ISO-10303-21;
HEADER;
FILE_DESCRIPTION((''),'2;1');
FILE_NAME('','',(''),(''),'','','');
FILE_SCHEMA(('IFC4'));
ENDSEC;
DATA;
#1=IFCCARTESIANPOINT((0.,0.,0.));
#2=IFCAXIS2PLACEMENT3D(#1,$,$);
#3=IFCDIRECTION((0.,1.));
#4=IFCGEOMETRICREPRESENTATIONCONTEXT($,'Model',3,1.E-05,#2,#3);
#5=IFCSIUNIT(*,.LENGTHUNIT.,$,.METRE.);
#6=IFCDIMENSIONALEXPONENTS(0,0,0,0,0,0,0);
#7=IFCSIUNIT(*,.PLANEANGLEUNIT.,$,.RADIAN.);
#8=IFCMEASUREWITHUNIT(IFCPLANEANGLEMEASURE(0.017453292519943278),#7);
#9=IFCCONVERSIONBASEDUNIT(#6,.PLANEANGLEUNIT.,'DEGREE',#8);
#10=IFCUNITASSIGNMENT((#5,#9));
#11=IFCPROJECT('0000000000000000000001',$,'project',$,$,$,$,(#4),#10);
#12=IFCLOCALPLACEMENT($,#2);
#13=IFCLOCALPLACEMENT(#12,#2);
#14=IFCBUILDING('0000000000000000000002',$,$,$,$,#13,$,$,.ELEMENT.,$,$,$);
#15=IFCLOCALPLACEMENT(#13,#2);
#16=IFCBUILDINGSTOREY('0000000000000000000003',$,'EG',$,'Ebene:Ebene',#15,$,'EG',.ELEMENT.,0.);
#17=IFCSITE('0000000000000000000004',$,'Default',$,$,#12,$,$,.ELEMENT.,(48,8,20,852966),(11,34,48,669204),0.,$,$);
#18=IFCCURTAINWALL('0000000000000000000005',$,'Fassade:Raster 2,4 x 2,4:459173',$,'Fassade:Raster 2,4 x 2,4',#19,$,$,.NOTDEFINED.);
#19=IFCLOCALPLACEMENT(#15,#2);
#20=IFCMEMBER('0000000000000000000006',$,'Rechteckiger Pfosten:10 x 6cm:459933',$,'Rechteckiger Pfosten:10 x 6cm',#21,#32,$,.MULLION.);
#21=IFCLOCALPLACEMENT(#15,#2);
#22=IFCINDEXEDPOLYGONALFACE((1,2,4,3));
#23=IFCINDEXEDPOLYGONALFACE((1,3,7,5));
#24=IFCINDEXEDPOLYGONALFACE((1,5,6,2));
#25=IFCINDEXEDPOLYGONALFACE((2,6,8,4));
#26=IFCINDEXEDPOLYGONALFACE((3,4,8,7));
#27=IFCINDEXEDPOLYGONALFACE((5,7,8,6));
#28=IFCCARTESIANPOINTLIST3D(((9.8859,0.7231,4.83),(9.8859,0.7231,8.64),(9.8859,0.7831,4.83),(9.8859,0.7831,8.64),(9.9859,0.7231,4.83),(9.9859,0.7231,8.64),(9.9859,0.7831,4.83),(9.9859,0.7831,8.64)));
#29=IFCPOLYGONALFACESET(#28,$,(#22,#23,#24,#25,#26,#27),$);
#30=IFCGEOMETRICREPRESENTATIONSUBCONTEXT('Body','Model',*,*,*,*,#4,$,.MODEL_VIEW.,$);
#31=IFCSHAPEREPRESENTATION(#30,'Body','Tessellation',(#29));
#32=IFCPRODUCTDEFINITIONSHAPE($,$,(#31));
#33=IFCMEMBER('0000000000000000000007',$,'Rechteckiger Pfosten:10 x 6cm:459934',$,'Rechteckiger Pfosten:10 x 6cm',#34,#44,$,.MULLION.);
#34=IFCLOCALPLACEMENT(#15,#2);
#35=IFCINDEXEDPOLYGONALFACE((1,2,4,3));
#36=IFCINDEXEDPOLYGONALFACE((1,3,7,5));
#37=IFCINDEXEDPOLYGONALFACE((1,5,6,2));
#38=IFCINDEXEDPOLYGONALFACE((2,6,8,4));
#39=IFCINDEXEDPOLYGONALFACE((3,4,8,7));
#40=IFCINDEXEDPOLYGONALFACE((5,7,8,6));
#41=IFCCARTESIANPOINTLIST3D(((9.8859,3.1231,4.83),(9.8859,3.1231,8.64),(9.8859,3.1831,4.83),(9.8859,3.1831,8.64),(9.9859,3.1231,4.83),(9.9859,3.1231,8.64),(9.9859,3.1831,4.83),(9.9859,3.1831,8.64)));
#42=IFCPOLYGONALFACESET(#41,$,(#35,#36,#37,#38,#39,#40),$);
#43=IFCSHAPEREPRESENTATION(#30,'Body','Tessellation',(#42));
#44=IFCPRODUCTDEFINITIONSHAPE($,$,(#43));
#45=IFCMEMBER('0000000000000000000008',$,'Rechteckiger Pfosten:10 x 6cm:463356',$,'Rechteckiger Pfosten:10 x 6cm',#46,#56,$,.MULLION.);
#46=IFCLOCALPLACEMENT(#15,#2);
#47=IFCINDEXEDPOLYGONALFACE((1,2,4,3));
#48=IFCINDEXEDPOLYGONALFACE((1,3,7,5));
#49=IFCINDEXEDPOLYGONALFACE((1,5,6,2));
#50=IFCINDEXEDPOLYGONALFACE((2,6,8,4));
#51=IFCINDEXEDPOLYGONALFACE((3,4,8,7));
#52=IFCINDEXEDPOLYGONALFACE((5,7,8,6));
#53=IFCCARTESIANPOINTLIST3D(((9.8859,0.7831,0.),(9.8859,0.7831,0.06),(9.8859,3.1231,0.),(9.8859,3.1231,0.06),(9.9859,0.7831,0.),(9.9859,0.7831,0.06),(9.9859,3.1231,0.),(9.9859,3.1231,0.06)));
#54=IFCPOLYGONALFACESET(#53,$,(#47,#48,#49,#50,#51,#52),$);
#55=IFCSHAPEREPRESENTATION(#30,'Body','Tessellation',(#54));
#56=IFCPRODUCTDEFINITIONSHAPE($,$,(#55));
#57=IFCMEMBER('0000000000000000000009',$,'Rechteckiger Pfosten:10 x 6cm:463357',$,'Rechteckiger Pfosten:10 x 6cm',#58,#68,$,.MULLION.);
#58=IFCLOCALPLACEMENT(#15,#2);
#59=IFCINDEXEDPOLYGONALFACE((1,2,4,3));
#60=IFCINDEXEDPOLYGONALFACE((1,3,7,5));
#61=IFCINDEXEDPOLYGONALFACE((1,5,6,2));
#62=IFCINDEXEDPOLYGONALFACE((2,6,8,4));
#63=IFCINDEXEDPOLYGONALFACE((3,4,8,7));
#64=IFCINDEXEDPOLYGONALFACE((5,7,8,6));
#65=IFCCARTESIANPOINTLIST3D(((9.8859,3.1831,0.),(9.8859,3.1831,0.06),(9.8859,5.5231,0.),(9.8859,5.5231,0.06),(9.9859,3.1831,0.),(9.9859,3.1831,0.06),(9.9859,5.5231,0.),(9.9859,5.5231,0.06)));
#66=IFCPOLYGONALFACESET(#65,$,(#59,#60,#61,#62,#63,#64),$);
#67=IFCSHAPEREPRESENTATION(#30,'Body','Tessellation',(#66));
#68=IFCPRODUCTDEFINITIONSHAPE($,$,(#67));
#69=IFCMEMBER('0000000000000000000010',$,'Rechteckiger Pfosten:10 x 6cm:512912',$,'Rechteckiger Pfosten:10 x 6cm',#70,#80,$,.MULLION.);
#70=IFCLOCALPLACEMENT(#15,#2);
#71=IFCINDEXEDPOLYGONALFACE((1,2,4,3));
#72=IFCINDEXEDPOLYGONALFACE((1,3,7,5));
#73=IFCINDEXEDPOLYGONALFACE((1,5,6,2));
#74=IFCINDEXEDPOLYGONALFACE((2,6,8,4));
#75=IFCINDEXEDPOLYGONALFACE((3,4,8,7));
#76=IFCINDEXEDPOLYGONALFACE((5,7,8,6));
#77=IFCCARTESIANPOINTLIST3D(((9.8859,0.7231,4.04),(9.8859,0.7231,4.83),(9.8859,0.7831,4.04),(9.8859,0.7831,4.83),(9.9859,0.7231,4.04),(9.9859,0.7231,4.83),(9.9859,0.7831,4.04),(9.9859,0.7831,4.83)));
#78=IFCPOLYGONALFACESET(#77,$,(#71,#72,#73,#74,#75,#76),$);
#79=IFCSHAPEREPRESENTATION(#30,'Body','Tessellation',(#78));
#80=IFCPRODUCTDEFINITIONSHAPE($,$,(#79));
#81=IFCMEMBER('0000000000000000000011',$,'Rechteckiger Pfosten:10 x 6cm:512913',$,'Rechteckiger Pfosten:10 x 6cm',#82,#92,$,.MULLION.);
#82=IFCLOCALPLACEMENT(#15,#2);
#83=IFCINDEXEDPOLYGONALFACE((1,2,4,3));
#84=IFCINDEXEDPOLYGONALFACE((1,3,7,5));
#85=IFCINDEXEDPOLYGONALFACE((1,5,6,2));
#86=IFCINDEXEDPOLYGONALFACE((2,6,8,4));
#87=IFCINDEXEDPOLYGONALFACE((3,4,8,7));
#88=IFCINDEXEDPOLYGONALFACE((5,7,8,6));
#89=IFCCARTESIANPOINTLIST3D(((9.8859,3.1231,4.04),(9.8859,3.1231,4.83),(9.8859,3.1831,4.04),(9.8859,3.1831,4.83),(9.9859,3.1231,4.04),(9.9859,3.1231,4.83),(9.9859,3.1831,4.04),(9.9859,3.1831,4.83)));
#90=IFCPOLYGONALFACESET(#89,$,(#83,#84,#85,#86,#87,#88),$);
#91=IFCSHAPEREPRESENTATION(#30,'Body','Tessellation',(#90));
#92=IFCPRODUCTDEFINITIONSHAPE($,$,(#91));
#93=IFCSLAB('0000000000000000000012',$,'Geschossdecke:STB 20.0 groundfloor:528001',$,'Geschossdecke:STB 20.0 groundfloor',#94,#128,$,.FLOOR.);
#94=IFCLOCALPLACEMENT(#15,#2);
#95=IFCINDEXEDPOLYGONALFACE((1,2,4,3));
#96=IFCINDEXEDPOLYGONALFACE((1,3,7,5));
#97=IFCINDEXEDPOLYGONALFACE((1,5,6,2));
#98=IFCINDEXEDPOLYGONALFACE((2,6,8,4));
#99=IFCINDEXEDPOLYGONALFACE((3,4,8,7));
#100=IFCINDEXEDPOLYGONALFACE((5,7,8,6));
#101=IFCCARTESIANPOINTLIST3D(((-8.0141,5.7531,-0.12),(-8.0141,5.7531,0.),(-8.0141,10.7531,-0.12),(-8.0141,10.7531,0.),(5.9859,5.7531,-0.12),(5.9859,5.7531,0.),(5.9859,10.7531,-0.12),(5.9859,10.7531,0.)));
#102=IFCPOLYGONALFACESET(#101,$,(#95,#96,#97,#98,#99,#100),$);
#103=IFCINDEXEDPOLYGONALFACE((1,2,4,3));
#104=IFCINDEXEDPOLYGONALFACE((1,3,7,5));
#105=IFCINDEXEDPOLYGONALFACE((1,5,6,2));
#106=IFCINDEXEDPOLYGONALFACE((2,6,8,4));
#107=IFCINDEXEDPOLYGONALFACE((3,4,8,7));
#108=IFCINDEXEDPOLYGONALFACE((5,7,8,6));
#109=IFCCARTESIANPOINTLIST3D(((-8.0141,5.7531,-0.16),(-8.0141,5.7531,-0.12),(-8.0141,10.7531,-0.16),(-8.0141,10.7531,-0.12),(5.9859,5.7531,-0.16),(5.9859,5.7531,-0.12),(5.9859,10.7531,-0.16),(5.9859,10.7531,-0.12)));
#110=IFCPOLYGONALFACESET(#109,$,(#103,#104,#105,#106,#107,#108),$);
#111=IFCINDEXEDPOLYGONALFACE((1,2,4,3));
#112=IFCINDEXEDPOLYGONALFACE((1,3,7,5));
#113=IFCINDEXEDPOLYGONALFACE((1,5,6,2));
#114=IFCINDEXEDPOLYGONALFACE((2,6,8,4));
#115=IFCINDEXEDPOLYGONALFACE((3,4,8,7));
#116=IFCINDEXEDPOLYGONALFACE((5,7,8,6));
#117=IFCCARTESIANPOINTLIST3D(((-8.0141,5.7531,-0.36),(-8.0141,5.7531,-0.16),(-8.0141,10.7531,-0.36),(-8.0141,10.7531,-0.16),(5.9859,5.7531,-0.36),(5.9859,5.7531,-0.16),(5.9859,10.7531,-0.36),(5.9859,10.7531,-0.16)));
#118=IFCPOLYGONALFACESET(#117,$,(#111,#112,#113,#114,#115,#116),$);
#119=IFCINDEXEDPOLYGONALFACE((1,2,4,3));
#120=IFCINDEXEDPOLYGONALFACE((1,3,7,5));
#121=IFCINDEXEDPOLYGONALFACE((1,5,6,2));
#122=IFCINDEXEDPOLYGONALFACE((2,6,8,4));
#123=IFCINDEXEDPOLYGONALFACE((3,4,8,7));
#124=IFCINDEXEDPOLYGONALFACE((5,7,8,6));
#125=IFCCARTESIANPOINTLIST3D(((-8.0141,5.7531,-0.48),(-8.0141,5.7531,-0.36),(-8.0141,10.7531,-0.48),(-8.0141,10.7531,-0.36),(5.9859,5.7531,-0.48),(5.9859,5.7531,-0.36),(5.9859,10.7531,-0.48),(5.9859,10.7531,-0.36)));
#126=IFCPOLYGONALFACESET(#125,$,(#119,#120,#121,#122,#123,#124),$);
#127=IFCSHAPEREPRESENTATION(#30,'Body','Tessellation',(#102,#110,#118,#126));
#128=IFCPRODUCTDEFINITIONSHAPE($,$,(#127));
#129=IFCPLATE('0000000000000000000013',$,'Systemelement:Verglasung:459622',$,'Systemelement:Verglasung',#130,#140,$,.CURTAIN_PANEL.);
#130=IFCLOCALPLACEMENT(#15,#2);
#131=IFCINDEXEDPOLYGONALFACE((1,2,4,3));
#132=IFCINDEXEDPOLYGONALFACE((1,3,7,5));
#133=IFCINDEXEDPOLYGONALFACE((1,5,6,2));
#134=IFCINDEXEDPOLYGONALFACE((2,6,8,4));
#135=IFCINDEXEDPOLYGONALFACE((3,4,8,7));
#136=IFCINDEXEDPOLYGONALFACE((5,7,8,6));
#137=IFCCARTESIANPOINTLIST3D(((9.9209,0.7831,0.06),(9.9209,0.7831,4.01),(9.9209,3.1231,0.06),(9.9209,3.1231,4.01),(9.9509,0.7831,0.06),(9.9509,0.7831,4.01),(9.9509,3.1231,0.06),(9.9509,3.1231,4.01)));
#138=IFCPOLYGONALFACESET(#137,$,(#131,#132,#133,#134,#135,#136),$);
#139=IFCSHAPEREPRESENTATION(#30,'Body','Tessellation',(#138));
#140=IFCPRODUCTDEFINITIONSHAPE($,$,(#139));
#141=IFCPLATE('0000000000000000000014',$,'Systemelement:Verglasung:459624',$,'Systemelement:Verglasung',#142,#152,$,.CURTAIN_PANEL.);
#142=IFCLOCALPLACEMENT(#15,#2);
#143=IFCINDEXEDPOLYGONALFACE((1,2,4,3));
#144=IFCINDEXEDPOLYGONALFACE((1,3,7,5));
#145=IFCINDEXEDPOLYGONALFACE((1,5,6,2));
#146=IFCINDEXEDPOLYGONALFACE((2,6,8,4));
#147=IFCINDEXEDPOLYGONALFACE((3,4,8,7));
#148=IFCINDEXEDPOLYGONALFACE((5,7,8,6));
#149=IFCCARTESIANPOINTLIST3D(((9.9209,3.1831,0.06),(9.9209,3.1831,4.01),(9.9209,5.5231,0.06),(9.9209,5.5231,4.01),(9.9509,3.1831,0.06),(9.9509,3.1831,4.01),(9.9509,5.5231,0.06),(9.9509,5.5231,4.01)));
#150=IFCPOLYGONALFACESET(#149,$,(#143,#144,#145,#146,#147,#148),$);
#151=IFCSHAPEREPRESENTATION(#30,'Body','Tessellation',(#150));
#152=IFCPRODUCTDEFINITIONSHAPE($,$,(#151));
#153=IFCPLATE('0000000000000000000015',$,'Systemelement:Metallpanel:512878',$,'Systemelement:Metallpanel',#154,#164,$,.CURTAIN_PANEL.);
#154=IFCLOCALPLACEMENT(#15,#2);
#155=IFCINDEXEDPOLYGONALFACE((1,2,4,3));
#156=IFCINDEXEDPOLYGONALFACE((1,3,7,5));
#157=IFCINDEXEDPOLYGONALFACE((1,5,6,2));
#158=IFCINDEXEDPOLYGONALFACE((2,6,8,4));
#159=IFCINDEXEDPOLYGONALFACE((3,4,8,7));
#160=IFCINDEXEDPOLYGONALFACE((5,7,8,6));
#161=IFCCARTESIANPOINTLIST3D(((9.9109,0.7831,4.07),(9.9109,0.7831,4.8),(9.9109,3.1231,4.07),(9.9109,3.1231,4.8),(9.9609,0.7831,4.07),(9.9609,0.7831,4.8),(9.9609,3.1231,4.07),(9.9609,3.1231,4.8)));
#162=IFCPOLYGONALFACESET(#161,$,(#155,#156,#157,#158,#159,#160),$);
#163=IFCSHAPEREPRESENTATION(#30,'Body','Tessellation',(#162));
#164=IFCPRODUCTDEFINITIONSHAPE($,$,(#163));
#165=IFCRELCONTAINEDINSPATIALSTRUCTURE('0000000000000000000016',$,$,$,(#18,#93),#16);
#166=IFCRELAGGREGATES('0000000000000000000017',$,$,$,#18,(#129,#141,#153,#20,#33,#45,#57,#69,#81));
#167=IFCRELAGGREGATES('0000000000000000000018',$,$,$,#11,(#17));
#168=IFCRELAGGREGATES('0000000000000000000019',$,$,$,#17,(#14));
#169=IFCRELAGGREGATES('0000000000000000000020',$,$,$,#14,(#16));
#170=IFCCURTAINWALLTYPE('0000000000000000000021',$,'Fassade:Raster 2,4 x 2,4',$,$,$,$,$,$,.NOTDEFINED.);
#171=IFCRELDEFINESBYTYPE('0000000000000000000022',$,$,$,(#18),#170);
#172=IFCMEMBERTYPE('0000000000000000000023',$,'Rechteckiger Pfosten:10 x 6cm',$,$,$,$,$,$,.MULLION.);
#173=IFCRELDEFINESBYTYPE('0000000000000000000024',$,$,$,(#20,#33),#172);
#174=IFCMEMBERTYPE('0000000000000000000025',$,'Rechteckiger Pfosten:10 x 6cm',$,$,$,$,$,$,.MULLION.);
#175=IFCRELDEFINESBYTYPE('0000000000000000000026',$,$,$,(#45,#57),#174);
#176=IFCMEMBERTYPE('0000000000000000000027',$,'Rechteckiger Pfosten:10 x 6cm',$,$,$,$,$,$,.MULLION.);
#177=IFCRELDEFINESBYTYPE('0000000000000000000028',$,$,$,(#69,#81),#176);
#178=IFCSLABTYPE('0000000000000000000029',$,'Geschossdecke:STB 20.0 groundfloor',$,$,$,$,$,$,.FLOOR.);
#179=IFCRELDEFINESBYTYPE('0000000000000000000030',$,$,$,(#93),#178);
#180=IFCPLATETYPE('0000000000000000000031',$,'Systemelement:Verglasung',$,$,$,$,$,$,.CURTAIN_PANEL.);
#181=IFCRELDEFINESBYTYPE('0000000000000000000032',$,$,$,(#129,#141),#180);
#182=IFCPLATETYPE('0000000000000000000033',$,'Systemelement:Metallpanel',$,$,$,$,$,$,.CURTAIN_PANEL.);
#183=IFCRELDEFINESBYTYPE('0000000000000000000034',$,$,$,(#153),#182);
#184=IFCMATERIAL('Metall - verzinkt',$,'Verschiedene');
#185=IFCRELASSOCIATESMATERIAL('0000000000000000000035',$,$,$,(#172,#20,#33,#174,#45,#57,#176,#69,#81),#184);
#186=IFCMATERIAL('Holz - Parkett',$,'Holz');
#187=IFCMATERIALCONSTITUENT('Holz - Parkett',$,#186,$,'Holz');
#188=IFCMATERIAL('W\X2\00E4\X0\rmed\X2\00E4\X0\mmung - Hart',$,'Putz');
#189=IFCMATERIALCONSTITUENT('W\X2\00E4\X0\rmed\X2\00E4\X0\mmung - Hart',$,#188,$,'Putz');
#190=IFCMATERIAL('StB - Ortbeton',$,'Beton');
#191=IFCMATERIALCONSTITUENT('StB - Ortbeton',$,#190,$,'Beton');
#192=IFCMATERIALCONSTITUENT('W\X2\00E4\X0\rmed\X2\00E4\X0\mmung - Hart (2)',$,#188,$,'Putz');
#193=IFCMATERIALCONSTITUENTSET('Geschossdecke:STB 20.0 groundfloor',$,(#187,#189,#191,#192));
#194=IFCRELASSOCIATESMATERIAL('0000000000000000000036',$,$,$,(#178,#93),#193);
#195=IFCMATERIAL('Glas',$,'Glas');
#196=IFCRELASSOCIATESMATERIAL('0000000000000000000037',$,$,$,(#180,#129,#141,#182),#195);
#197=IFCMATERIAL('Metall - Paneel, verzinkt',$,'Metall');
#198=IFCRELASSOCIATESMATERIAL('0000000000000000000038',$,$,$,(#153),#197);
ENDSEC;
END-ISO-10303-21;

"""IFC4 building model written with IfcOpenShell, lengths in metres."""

from ifc_helpers import new_model, entity, si_unit, converted_unit, direction, frame, origin, place, context, subcontext, project, spatial, indexed_curve, outline, extrude, source, transform, mapped, material, constituent, constituent_set, type_object, type_shapes, element, aggregate, save


model = new_model("IFC4")

# Units and contexts
model_context = context("Model", 3, precision=1e-05, world=origin(), true_north=direction((0.0, 1.0)))
body_context = subcontext(model_context, "Body", "Model", "MODEL_VIEW")
ifc_project = project(units=[si_unit("LENGTHUNIT", "METRE"), converted_unit("PLANEANGLEUNIT", "DEGREE", entity("IfcPlaneAngleMeasure", 0.017453292519943278), si_unit("PLANEANGLEUNIT", "RADIAN"), dimensions=[0, 0, 0, 0, 0, 0, 0])], contexts=[model_context])

# Site, building, storey
site_placement = place(None, origin())
site = spatial("IfcSite", under=ifc_project, at=site_placement, Name="Default", CompositionType="ELEMENT", RefLatitude=(48, 8, 20, 852966), RefLongitude=(11, 34, 48, 669204), RefElevation=0.0)
building_placement = place(site_placement, origin())
building = spatial("IfcBuilding", under=site, at=building_placement, CompositionType="ELEMENT")
storey_placement = place(building_placement, origin())
storey = spatial("IfcBuildingStorey", under=building, at=storey_placement, Name="EG", ObjectType="Ebene:Ebene", LongName="EG", CompositionType="ELEMENT", Elevation=0.0)

# Curtain wall, members
curtain_wall_type = type_object("IfcCurtainWallType", Name="Fassade:Raster 2,4 x 2,4", PredefinedType="NOTDEFINED")
curtain_wall_placement = place(storey_placement, origin())
curtain_wall = element("IfcCurtainWall", 1, at=curtain_wall_placement, inside=storey, type_object=curtain_wall_type, Name="Fassade:Raster 2,4 x 2,4:459173", ObjectType="Fassade:Raster 2,4 x 2,4", PredefinedType="NOTDEFINED")
ifc_material_1 = material(Name="Metall - verzinkt", Category="Verschiedene")
member_type_1 = type_object("IfcMemberType", Name="Rechteckiger Pfosten:10 x 6cm", PredefinedType="MULLION", material=ifc_material_1)
shared_shape_1 = source(origin(), body_context, "Body", "SweptSolid", [
    extrude(outline(indexed_curve([(-0.03, -0.05), (0.03, -0.05), (0.03, 0.05), (-0.03, 0.05), (-0.03, -0.05)], self_intersect=False)), frame((0.0, 0.0, -3.81), z_axis=(0.0, 0.0, 1.0), x_axis=(-1.0, 0.0, 0.0)), (0.0, 0.0, 1.0), 3.81),
])
type_shapes(member_type_1, [shared_shape_1])
member_1_placement = place(curtain_wall_placement, frame((9.9359, 0.7531, 4.83), z_axis=(0.0, 0.0, -1.0), x_axis=(0.0, 1.0, 0.0)))
member_1 = element("IfcMember", 2, at=member_1_placement, type_object=member_type_1, material=ifc_material_1, Name="Rechteckiger Pfosten:10 x 6cm:459933", ObjectType="Rechteckiger Pfosten:10 x 6cm", PredefinedType="MULLION", context=body_context, shape_type="MappedRepresentation", body=[
    mapped(shared_shape_1, transform((0.0, 0.0, 0.0), scale=1.0)),
])
member_2_placement = place(curtain_wall_placement, frame((9.9359, 3.1531, 4.83), z_axis=(0.0, 0.0, -1.0), x_axis=(0.0, 1.0, 0.0)))
member_2 = element("IfcMember", 3, at=member_2_placement, type_object=member_type_1, material=ifc_material_1, Name="Rechteckiger Pfosten:10 x 6cm:459934", ObjectType="Rechteckiger Pfosten:10 x 6cm", PredefinedType="MULLION", context=body_context, shape_type="MappedRepresentation", body=[
    mapped(shared_shape_1, transform((0.0, 0.0, 0.0), scale=1.0)),
])
member_type_2 = type_object("IfcMemberType", Name="Rechteckiger Pfosten:10 x 6cm", PredefinedType="MULLION", material=ifc_material_1)
shared_shape_2 = source(origin(), body_context, "Body", "SweptSolid", [
    extrude(outline(indexed_curve([(-0.03, -0.05), (0.03, -0.05), (0.03, 0.05), (-0.03, 0.05), (-0.03, -0.05)], self_intersect=False)), frame((-0.03, 0.0, -2.34), z_axis=(0.0, 0.0, 1.0), x_axis=(-1.0, 0.0, 0.0)), (0.0, 0.0, 1.0), 2.34),
])
type_shapes(member_type_2, [shared_shape_2])
member_3_placement = place(curtain_wall_placement, frame((9.9359, 0.7831, 0.0), z_axis=(0.0, -1.0, 0.0), x_axis=(0.0, 0.0, -1.0)))
member_3 = element("IfcMember", 4, at=member_3_placement, type_object=member_type_2, material=ifc_material_1, Name="Rechteckiger Pfosten:10 x 6cm:463356", ObjectType="Rechteckiger Pfosten:10 x 6cm", PredefinedType="MULLION", context=body_context, shape_type="MappedRepresentation", body=[
    mapped(shared_shape_2, transform((0.0, 0.0, 0.0), scale=1.0)),
])
member_4_placement = place(curtain_wall_placement, frame((9.9359, 3.1831, 0.0), z_axis=(0.0, -1.0, 0.0), x_axis=(0.0, 0.0, -1.0)))
member_4 = element("IfcMember", 5, at=member_4_placement, type_object=member_type_2, material=ifc_material_1, Name="Rechteckiger Pfosten:10 x 6cm:463357", ObjectType="Rechteckiger Pfosten:10 x 6cm", PredefinedType="MULLION", context=body_context, shape_type="MappedRepresentation", body=[
    mapped(shared_shape_2, transform((0.0, 0.0, 0.0), scale=1.0)),
])
member_type_3 = type_object("IfcMemberType", Name="Rechteckiger Pfosten:10 x 6cm", PredefinedType="MULLION", material=ifc_material_1)
shared_shape_3 = source(origin(), body_context, "Body", "SweptSolid", [
    extrude(outline(indexed_curve([(-0.03, -0.05), (0.03, -0.05), (0.03, 0.05), (-0.03, 0.05), (-0.03, -0.05)], self_intersect=False)), frame((0.0, 0.0, -0.79), z_axis=(0.0, 0.0, 1.0), x_axis=(-1.0, 0.0, 0.0)), (0.0, 0.0, 1.0), 0.79),
])
type_shapes(member_type_3, [shared_shape_3])
member_5_placement = place(curtain_wall_placement, frame((9.9359, 0.7531, 4.04), z_axis=(0.0, 0.0, -1.0), x_axis=(0.0, 1.0, 0.0)))
member_5 = element("IfcMember", 6, at=member_5_placement, type_object=member_type_3, material=ifc_material_1, Name="Rechteckiger Pfosten:10 x 6cm:512912", ObjectType="Rechteckiger Pfosten:10 x 6cm", PredefinedType="MULLION", context=body_context, shape_type="MappedRepresentation", body=[
    mapped(shared_shape_3, transform((0.0, 0.0, 0.0), scale=1.0)),
])
member_6_placement = place(curtain_wall_placement, frame((9.9359, 3.1531, 4.04), z_axis=(0.0, 0.0, -1.0), x_axis=(0.0, 1.0, 0.0)))
member_6 = element("IfcMember", 7, at=member_6_placement, type_object=member_type_3, material=ifc_material_1, Name="Rechteckiger Pfosten:10 x 6cm:512913", ObjectType="Rechteckiger Pfosten:10 x 6cm", PredefinedType="MULLION", context=body_context, shape_type="MappedRepresentation", body=[
    mapped(shared_shape_3, transform((0.0, 0.0, 0.0), scale=1.0)),
])

# Slab
ifc_material_2 = material(Name="Holz - Parkett", Category="Holz")
ifc_constituent_1 = constituent(ifc_material_2, Name="Holz - Parkett", Category="Holz")
ifc_material_3 = material(Name="Wärmedämmung - Hart", Category="Putz")
ifc_constituent_2 = constituent(ifc_material_3, Name="Wärmedämmung - Hart", Category="Putz")
ifc_material_4 = material(Name="StB - Ortbeton", Category="Beton")
ifc_constituent_3 = constituent(ifc_material_4, Name="StB - Ortbeton", Category="Beton")
ifc_constituent_4 = constituent(ifc_material_3, Name="Wärmedämmung - Hart (2)", Category="Putz")
ifc_constituent_set_1 = constituent_set(constituents=[ifc_constituent_1, ifc_constituent_2, ifc_constituent_3, ifc_constituent_4], Name="Geschossdecke:STB 20.0 groundfloor")
slab_type = type_object("IfcSlabType", Name="Geschossdecke:STB 20.0 groundfloor", PredefinedType="FLOOR", material=ifc_constituent_set_1)
slab_placement = place(storey_placement, origin())
element("IfcSlab", 8, at=slab_placement, inside=storey, type_object=slab_type, material=ifc_constituent_set_1, Name="Geschossdecke:STB 20.0 groundfloor:528001", ObjectType="Geschossdecke:STB 20.0 groundfloor", PredefinedType="FLOOR", context=body_context, shape_type="SweptSolid", body=[
    extrude(outline(indexed_curve([(-7.0, -2.5), (7.0, -2.5), (7.0, 2.5), (-7.0, 2.5), (-7.0, -2.5)], self_intersect=False)), frame((-1.0141, 8.2531, -0.12), z_axis=(0.0, 0.0, 1.0), x_axis=(-1.0, 0.0, 0.0)), (0.0, 0.0, 1.0), 0.12),
    extrude(outline(indexed_curve([(-7.0, -2.5), (7.0, -2.5), (7.0, 2.5), (-7.0, 2.5), (-7.0, -2.5)], self_intersect=False)), frame((-1.0141, 8.2531, -0.16), z_axis=(0.0, 0.0, 1.0), x_axis=(-1.0, 0.0, 0.0)), (0.0, 0.0, 1.0), 0.04),
    extrude(outline(indexed_curve([(-7.0, -2.5), (7.0, -2.5), (7.0, 2.5), (-7.0, 2.5), (-7.0, -2.5)], self_intersect=False)), frame((-1.0141, 8.2531, -0.36), z_axis=(0.0, 0.0, 1.0), x_axis=(-1.0, 0.0, 0.0)), (0.0, 0.0, 1.0), 0.2),
    extrude(outline(indexed_curve([(-2.5, -7.0), (2.5, -7.0), (2.5, 7.0), (-2.5, 7.0), (-2.5, -7.0)], self_intersect=False)), frame((-1.0141, 8.2531, -0.48), z_axis=(0.0, 0.0, 1.0), x_axis=(0.0, 1.0, 0.0)), (0.0, 0.0, 1.0), 0.12),
])

# Plates
ifc_material_5 = material(Name="Glas", Category="Glas")
plate_type_1 = type_object("IfcPlateType", Name="Systemelement:Verglasung", PredefinedType="CURTAIN_PANEL", material=ifc_material_5)
shared_shape_4 = source(origin(), body_context, "Body", "SweptSolid", [
    extrude(outline(indexed_curve([(-0.015, -1.17), (0.015, -1.17), (0.015, 1.17), (-0.015, 1.17), (-0.015, -1.17)], self_intersect=False)), frame((0.0, 0.0, 0.0), z_axis=(0.0, 0.0, 1.0), x_axis=(0.0, 1.0, 0.0)), (0.0, 0.0, 1.0), 3.95),
])
type_shapes(plate_type_1, [shared_shape_4])
plate_1_placement = place(curtain_wall_placement, frame((9.9359, 1.9531, 0.06), z_axis=(0.0, 0.0, 1.0), x_axis=(0.0, 1.0, 0.0)))
plate_1 = element("IfcPlate", 9, at=plate_1_placement, type_object=plate_type_1, material=ifc_material_5, Name="Systemelement:Verglasung:459622", ObjectType="Systemelement:Verglasung", PredefinedType="CURTAIN_PANEL", context=body_context, shape_type="MappedRepresentation", body=[
    mapped(shared_shape_4, transform((0.0, 0.0, 0.0), scale=1.0)),
])
plate_2_placement = place(curtain_wall_placement, frame((9.9359, 4.3531, 0.06), z_axis=(0.0, 0.0, 1.0), x_axis=(0.0, 1.0, 0.0)))
plate_2 = element("IfcPlate", 10, at=plate_2_placement, type_object=plate_type_1, material=ifc_material_5, Name="Systemelement:Verglasung:459624", ObjectType="Systemelement:Verglasung", PredefinedType="CURTAIN_PANEL", context=body_context, shape_type="MappedRepresentation", body=[
    mapped(shared_shape_4, transform((0.0, 0.0, 0.0), scale=1.0)),
])
ifc_material_6 = material(Name="Metall - Paneel, verzinkt", Category="Metall")
plate_type_2 = type_object("IfcPlateType", Name="Systemelement:Metallpanel", PredefinedType="CURTAIN_PANEL", material=ifc_material_5)
shared_shape_5 = source(origin(), body_context, "Body", "SweptSolid", [
    extrude(outline(indexed_curve([(-0.025, -1.17), (0.025, -1.17), (0.025, 1.17), (-0.025, 1.17), (-0.025, -1.17)], self_intersect=False)), frame((0.0, 0.0, 0.0), z_axis=(0.0, 0.0, 1.0), x_axis=(0.0, 1.0, 0.0)), (0.0, 0.0, 1.0), 0.73),
])
type_shapes(plate_type_2, [shared_shape_5])
plate_3_placement = place(curtain_wall_placement, frame((9.9359, 1.9531, 4.07), z_axis=(0.0, 0.0, 1.0), x_axis=(0.0, 1.0, 0.0)))
plate_3 = element("IfcPlate", 11, at=plate_3_placement, type_object=plate_type_2, material=ifc_material_6, Name="Systemelement:Metallpanel:512878", ObjectType="Systemelement:Metallpanel", PredefinedType="CURTAIN_PANEL", context=body_context, shape_type="MappedRepresentation", body=[
    mapped(shared_shape_5, transform((0.0, 0.0, 0.0), scale=1.0)),
])
aggregate(curtain_wall, [plate_1, plate_2, plate_3, member_1, member_2, member_3, member_4, member_5, member_6])

save(model, "model.ifc")
